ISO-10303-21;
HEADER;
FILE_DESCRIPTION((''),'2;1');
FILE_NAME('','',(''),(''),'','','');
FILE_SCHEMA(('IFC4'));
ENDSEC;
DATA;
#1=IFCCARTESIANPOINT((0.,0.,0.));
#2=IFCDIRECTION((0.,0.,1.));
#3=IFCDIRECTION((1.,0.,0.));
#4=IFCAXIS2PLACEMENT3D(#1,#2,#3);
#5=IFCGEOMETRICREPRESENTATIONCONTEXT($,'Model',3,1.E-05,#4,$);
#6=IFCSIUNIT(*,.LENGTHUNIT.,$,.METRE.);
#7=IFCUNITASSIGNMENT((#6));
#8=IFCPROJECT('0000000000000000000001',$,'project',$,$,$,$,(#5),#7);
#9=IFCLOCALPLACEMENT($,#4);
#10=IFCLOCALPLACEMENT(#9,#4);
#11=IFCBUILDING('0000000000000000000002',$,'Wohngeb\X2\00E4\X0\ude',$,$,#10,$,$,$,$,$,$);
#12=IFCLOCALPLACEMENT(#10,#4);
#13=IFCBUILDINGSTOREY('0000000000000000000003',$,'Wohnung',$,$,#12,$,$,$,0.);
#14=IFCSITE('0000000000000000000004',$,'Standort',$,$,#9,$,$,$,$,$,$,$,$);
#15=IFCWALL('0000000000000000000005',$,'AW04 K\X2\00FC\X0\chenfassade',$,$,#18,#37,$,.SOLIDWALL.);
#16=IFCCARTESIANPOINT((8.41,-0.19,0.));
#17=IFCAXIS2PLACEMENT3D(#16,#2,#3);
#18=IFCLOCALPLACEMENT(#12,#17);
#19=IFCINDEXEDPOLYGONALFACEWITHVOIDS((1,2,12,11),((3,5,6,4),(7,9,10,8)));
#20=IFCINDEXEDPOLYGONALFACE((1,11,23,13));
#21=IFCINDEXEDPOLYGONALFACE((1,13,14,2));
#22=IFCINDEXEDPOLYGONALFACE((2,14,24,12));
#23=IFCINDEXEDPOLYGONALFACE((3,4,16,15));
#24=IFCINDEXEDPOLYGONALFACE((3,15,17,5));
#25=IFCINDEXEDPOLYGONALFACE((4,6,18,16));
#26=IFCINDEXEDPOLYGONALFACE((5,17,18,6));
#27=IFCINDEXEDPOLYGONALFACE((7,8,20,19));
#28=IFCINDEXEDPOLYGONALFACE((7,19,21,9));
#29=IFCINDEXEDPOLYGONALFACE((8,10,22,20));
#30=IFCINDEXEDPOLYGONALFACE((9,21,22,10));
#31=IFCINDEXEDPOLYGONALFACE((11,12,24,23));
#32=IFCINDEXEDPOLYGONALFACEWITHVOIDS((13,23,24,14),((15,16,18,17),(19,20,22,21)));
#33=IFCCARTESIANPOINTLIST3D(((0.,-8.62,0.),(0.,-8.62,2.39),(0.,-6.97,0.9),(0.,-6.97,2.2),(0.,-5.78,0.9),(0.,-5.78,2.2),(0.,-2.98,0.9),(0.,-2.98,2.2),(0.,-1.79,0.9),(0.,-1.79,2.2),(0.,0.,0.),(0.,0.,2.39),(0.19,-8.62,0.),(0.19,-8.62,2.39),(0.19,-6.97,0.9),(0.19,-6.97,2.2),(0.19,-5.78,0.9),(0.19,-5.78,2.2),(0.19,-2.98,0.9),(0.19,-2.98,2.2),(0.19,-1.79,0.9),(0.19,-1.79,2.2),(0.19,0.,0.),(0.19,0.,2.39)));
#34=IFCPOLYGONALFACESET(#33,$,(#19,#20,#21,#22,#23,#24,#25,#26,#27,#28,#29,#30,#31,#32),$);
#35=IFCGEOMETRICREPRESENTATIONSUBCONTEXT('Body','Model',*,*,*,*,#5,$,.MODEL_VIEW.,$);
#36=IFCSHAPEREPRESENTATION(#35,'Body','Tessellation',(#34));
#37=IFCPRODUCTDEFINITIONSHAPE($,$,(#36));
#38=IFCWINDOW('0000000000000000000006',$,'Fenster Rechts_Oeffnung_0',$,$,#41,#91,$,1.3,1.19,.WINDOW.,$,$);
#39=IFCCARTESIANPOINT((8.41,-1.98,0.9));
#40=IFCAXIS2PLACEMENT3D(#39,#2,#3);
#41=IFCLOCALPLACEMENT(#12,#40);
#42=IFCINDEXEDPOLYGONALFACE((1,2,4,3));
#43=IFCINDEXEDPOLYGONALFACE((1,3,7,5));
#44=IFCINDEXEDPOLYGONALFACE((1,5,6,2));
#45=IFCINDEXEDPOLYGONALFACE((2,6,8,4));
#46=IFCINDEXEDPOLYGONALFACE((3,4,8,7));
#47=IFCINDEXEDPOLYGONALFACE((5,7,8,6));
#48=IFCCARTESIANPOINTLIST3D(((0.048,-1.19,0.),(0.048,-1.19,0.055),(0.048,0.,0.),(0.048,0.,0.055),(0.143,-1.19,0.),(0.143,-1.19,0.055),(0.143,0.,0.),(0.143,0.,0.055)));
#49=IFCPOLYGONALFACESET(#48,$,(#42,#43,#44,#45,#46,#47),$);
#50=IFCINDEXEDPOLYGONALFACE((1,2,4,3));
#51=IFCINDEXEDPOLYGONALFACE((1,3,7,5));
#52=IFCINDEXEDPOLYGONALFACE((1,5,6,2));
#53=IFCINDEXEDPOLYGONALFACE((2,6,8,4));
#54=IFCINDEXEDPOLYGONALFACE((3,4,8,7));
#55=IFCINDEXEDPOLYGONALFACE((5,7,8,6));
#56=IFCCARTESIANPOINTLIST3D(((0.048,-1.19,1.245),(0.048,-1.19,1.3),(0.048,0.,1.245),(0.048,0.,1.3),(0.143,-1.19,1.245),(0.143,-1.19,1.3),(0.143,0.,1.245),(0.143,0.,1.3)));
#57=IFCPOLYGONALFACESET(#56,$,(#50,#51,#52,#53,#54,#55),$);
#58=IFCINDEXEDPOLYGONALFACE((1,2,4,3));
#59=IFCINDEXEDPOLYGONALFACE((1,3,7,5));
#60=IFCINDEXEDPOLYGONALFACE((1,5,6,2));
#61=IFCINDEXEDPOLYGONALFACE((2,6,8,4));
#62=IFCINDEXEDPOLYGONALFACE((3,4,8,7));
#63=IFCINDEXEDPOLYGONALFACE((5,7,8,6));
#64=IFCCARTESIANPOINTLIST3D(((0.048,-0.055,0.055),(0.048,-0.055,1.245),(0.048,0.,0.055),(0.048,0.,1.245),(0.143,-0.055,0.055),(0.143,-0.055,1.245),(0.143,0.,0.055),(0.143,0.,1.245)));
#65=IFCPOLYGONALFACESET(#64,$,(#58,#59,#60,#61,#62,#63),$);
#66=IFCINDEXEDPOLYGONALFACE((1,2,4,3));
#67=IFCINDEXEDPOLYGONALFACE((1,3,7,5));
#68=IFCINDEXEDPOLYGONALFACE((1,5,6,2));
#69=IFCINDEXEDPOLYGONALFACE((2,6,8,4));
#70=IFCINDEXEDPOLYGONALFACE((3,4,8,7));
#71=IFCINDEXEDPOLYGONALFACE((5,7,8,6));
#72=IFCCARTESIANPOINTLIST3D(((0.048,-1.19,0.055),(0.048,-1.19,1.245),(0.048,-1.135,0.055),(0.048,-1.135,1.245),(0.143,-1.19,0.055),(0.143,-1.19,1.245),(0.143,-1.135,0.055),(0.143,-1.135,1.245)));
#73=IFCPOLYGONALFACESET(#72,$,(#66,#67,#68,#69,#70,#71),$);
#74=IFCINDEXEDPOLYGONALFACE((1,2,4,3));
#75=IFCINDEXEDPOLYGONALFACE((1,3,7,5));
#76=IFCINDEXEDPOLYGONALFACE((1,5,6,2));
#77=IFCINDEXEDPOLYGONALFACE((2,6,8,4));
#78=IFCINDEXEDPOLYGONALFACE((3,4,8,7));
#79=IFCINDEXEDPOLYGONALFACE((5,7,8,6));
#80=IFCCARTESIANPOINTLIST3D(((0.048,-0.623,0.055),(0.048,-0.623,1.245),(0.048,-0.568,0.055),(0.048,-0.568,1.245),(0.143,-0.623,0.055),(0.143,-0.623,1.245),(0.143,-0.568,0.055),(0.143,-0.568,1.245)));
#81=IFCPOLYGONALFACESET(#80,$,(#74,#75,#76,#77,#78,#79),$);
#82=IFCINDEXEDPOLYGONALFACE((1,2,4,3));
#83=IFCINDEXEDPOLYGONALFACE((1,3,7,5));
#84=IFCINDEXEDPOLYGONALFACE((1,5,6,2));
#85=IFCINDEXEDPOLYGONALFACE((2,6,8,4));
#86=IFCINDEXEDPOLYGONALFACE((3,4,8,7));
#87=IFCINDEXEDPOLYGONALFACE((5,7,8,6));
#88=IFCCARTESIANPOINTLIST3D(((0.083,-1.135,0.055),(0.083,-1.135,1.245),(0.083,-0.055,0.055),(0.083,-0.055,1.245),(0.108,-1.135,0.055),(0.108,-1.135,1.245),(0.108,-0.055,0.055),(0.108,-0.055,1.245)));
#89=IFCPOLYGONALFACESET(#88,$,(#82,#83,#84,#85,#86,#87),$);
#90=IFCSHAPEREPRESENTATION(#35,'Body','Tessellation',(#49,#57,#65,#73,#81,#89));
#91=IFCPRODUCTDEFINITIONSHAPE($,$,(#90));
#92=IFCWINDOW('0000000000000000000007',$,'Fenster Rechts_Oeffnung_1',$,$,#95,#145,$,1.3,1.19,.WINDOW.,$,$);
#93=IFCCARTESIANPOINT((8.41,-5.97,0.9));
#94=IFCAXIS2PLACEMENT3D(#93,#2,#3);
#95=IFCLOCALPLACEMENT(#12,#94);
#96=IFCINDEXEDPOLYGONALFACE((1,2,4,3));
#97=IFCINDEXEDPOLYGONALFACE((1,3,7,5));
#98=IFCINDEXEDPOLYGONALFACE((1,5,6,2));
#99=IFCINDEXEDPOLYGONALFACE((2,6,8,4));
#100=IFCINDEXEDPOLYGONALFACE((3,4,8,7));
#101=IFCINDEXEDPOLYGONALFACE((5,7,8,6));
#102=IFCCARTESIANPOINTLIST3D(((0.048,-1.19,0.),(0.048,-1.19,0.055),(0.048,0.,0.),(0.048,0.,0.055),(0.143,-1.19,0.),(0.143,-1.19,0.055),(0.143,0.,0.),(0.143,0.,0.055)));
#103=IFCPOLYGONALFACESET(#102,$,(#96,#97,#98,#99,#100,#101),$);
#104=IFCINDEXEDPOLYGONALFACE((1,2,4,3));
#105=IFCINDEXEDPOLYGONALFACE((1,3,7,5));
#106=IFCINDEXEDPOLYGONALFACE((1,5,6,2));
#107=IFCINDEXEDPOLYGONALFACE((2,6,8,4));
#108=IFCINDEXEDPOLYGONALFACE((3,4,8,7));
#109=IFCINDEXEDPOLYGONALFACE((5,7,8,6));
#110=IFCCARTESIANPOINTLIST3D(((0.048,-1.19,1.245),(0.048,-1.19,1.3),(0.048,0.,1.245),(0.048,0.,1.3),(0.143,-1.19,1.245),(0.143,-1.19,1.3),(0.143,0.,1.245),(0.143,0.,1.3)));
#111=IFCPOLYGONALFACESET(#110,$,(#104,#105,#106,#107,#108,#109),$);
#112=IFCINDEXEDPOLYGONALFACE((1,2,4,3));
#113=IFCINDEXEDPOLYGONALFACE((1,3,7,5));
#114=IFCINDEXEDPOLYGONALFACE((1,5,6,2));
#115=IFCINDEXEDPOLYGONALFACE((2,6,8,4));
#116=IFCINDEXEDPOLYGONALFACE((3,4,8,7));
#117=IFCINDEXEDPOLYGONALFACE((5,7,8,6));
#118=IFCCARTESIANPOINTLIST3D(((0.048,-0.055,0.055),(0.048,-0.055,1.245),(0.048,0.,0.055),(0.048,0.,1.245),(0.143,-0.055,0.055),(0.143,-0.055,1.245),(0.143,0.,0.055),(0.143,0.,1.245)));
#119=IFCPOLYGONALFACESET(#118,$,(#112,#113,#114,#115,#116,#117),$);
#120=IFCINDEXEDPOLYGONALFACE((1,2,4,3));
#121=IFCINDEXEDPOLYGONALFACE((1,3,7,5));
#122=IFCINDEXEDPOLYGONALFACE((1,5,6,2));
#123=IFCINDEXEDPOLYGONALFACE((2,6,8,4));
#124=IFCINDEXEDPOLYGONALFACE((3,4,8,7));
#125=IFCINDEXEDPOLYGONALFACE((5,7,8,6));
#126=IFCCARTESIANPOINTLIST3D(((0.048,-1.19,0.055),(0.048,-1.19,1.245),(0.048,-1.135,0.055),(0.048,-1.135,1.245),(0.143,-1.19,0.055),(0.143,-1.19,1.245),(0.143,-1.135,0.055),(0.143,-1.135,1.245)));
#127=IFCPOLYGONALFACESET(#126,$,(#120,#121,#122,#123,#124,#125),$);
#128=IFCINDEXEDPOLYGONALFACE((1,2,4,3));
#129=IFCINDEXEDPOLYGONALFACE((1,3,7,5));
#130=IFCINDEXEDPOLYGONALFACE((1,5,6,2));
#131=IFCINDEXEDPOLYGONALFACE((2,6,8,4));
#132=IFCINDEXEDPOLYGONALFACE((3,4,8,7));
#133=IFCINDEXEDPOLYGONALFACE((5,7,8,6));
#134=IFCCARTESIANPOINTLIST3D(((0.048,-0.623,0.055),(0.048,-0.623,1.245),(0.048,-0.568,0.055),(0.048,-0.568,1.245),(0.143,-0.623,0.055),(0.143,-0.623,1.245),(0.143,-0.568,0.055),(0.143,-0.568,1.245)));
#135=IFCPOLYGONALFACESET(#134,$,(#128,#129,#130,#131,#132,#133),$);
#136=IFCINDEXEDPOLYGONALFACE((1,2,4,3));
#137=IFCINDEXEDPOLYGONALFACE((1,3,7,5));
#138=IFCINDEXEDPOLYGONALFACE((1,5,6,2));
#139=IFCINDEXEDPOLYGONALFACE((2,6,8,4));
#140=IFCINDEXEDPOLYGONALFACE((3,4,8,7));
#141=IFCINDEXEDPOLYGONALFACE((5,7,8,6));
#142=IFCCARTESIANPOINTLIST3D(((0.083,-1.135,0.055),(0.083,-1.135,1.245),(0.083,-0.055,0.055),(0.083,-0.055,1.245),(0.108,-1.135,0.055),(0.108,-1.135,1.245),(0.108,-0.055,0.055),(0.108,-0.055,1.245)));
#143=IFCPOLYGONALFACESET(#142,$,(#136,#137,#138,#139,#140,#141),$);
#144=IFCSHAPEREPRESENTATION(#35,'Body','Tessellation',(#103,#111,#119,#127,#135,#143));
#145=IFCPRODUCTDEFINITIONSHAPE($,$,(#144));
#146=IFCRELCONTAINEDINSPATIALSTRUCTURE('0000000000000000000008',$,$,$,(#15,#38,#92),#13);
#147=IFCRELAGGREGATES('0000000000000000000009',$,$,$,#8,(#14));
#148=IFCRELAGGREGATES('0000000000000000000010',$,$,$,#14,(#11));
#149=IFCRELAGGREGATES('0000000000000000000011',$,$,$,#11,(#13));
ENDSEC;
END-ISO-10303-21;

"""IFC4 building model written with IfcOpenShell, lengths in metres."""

from ifc_helpers import new_model, si_unit, frame, origin, origin_with_axes, place, context, subcontext, project, spatial, polyline, outline, extrude, element, fill, save


model = new_model("IFC4")

# Units and contexts
model_context = context("Model", 3, precision=1e-05, world=origin_with_axes())
body_context = subcontext(model_context, "Body", "Model", "MODEL_VIEW")
ifc_project = project(units=[si_unit("LENGTHUNIT", "METRE")], contexts=[model_context])

# Site, building, storey
site_placement = place(None, origin_with_axes())
site = spatial("IfcSite", under=ifc_project, at=site_placement, Name="Standort")
building_placement = place(site_placement, origin_with_axes())
building = spatial("IfcBuilding", under=site, at=building_placement, Name="Wohngebäude")
storey_placement = place(building_placement, origin_with_axes())
storey = spatial("IfcBuildingStorey", under=building, at=storey_placement, Name="Wohnung", Elevation=0.0)

# Wall, openings, windows
wall_placement = place(storey_placement, frame((8.41, -0.19, 0.0), z_axis=(0.0, 0.0, 1.0), x_axis=(1.0, 0.0, 0.0)))
wall = element("IfcWall", 1, at=wall_placement, inside=storey, Name="AW04 Küchenfassade", PredefinedType="SOLIDWALL", context=body_context, shape_type="SweptSolid", body=[
    extrude(outline(polyline([(0.0, 0.0), (0.0, -8.62), (0.19, -8.62), (0.19, 0.0), (0.0, 0.0)])), origin(), (0.0, 0.0, 1.0), 2.39),
])
opening_1_placement = place(wall_placement, frame((0.0, -1.79, 0.9), z_axis=(0.0, 0.0, 1.0), x_axis=(1.0, 0.0, 0.0)))
opening_1 = element("IfcOpeningElement", 2, at=opening_1_placement, cuts=wall, PredefinedType="OPENING", context=body_context, shape_type="SweptSolid", body=[
    extrude(outline(polyline([(-0.005, 0.0), (-0.005, -1.19), (0.195, -1.19), (0.195, 0.0), (-0.005, 0.0)])), origin(), (0.0, 0.0, 1.0), 1.3),
])
opening_2_placement = place(wall_placement, frame((0.0, -5.78, 0.9), z_axis=(0.0, 0.0, 1.0), x_axis=(1.0, 0.0, 0.0)))
opening_2 = element("IfcOpeningElement", 3, at=opening_2_placement, cuts=wall, PredefinedType="OPENING", context=body_context, shape_type="SweptSolid", body=[
    extrude(outline(polyline([(-0.005, 0.0), (-0.005, -1.19), (0.195, -1.19), (0.195, 0.0), (-0.005, 0.0)])), origin(), (0.0, 0.0, 1.0), 1.3),
])
window_1_placement = place(storey_placement, frame((8.41, -1.98, 0.9), z_axis=(0.0, 0.0, 1.0), x_axis=(1.0, 0.0, 0.0)))
window_1 = element("IfcWindow", 4, at=window_1_placement, inside=storey, Name="Fenster Rechts_Oeffnung_0", OverallHeight=1.3, OverallWidth=1.19, PredefinedType="WINDOW", context=body_context, shape_type="SweptSolid", body=[
    extrude(outline(polyline([(0.048, 0.0), (0.048, -1.19), (0.143, -1.19), (0.143, 0.0), (0.048, 0.0)])), origin(), (0.0, 0.0, 1.0), 0.055),
    extrude(outline(polyline([(0.048, 0.0), (0.048, -1.19), (0.143, -1.19), (0.143, 0.0), (0.048, 0.0)])), frame((0.0, 0.0, 1.245)), (0.0, 0.0, 1.0), 0.055),
    extrude(outline(polyline([(0.048, 0.0), (0.048, -0.055), (0.143, -0.055), (0.143, 0.0), (0.048, 0.0)])), frame((0.0, 0.0, 0.055)), (0.0, 0.0, 1.0), 1.19),
    extrude(outline(polyline([(0.048, -1.135), (0.048, -1.19), (0.143, -1.19), (0.143, -1.135), (0.048, -1.135)])), frame((0.0, 0.0, 0.055)), (0.0, 0.0, 1.0), 1.19),
    extrude(outline(polyline([(0.048, -0.568), (0.048, -0.623), (0.143, -0.623), (0.143, -0.568), (0.048, -0.568)])), frame((0.0, 0.0, 0.055)), (0.0, 0.0, 1.0), 1.19),
    extrude(outline(polyline([(0.083, -0.055), (0.083, -1.135), (0.108, -1.135), (0.108, -0.055), (0.083, -0.055)])), frame((0.0, 0.0, 0.055)), (0.0, 0.0, 1.0), 1.19),
])
fill(opening_1, window_1)
window_2_placement = place(storey_placement, frame((8.41, -5.97, 0.9), z_axis=(0.0, 0.0, 1.0), x_axis=(1.0, 0.0, 0.0)))
window_2 = element("IfcWindow", 5, at=window_2_placement, inside=storey, Name="Fenster Rechts_Oeffnung_1", OverallHeight=1.3, OverallWidth=1.19, PredefinedType="WINDOW", context=body_context, shape_type="SweptSolid", body=[
    extrude(outline(polyline([(0.048, 0.0), (0.048, -1.19), (0.143, -1.19), (0.143, 0.0), (0.048, 0.0)])), origin(), (0.0, 0.0, 1.0), 0.055),
    extrude(outline(polyline([(0.048, 0.0), (0.048, -1.19), (0.143, -1.19), (0.143, 0.0), (0.048, 0.0)])), frame((0.0, 0.0, 1.245)), (0.0, 0.0, 1.0), 0.055),
    extrude(outline(polyline([(0.048, 0.0), (0.048, -0.055), (0.143, -0.055), (0.143, 0.0), (0.048, 0.0)])), frame((0.0, 0.0, 0.055)), (0.0, 0.0, 1.0), 1.19),
    extrude(outline(polyline([(0.048, -1.135), (0.048, -1.19), (0.143, -1.19), (0.143, -1.135), (0.048, -1.135)])), frame((0.0, 0.0, 0.055)), (0.0, 0.0, 1.0), 1.19),
    extrude(outline(polyline([(0.048, -0.568), (0.048, -0.623), (0.143, -0.623), (0.143, -0.568), (0.048, -0.568)])), frame((0.0, 0.0, 0.055)), (0.0, 0.0, 1.0), 1.19),
    extrude(outline(polyline([(0.083, -0.055), (0.083, -1.135), (0.108, -1.135), (0.108, -0.055), (0.083, -0.055)])), frame((0.0, 0.0, 0.055)), (0.0, 0.0, 1.0), 1.19),
])
fill(opening_2, window_2)

save(model, "model.ifc")
